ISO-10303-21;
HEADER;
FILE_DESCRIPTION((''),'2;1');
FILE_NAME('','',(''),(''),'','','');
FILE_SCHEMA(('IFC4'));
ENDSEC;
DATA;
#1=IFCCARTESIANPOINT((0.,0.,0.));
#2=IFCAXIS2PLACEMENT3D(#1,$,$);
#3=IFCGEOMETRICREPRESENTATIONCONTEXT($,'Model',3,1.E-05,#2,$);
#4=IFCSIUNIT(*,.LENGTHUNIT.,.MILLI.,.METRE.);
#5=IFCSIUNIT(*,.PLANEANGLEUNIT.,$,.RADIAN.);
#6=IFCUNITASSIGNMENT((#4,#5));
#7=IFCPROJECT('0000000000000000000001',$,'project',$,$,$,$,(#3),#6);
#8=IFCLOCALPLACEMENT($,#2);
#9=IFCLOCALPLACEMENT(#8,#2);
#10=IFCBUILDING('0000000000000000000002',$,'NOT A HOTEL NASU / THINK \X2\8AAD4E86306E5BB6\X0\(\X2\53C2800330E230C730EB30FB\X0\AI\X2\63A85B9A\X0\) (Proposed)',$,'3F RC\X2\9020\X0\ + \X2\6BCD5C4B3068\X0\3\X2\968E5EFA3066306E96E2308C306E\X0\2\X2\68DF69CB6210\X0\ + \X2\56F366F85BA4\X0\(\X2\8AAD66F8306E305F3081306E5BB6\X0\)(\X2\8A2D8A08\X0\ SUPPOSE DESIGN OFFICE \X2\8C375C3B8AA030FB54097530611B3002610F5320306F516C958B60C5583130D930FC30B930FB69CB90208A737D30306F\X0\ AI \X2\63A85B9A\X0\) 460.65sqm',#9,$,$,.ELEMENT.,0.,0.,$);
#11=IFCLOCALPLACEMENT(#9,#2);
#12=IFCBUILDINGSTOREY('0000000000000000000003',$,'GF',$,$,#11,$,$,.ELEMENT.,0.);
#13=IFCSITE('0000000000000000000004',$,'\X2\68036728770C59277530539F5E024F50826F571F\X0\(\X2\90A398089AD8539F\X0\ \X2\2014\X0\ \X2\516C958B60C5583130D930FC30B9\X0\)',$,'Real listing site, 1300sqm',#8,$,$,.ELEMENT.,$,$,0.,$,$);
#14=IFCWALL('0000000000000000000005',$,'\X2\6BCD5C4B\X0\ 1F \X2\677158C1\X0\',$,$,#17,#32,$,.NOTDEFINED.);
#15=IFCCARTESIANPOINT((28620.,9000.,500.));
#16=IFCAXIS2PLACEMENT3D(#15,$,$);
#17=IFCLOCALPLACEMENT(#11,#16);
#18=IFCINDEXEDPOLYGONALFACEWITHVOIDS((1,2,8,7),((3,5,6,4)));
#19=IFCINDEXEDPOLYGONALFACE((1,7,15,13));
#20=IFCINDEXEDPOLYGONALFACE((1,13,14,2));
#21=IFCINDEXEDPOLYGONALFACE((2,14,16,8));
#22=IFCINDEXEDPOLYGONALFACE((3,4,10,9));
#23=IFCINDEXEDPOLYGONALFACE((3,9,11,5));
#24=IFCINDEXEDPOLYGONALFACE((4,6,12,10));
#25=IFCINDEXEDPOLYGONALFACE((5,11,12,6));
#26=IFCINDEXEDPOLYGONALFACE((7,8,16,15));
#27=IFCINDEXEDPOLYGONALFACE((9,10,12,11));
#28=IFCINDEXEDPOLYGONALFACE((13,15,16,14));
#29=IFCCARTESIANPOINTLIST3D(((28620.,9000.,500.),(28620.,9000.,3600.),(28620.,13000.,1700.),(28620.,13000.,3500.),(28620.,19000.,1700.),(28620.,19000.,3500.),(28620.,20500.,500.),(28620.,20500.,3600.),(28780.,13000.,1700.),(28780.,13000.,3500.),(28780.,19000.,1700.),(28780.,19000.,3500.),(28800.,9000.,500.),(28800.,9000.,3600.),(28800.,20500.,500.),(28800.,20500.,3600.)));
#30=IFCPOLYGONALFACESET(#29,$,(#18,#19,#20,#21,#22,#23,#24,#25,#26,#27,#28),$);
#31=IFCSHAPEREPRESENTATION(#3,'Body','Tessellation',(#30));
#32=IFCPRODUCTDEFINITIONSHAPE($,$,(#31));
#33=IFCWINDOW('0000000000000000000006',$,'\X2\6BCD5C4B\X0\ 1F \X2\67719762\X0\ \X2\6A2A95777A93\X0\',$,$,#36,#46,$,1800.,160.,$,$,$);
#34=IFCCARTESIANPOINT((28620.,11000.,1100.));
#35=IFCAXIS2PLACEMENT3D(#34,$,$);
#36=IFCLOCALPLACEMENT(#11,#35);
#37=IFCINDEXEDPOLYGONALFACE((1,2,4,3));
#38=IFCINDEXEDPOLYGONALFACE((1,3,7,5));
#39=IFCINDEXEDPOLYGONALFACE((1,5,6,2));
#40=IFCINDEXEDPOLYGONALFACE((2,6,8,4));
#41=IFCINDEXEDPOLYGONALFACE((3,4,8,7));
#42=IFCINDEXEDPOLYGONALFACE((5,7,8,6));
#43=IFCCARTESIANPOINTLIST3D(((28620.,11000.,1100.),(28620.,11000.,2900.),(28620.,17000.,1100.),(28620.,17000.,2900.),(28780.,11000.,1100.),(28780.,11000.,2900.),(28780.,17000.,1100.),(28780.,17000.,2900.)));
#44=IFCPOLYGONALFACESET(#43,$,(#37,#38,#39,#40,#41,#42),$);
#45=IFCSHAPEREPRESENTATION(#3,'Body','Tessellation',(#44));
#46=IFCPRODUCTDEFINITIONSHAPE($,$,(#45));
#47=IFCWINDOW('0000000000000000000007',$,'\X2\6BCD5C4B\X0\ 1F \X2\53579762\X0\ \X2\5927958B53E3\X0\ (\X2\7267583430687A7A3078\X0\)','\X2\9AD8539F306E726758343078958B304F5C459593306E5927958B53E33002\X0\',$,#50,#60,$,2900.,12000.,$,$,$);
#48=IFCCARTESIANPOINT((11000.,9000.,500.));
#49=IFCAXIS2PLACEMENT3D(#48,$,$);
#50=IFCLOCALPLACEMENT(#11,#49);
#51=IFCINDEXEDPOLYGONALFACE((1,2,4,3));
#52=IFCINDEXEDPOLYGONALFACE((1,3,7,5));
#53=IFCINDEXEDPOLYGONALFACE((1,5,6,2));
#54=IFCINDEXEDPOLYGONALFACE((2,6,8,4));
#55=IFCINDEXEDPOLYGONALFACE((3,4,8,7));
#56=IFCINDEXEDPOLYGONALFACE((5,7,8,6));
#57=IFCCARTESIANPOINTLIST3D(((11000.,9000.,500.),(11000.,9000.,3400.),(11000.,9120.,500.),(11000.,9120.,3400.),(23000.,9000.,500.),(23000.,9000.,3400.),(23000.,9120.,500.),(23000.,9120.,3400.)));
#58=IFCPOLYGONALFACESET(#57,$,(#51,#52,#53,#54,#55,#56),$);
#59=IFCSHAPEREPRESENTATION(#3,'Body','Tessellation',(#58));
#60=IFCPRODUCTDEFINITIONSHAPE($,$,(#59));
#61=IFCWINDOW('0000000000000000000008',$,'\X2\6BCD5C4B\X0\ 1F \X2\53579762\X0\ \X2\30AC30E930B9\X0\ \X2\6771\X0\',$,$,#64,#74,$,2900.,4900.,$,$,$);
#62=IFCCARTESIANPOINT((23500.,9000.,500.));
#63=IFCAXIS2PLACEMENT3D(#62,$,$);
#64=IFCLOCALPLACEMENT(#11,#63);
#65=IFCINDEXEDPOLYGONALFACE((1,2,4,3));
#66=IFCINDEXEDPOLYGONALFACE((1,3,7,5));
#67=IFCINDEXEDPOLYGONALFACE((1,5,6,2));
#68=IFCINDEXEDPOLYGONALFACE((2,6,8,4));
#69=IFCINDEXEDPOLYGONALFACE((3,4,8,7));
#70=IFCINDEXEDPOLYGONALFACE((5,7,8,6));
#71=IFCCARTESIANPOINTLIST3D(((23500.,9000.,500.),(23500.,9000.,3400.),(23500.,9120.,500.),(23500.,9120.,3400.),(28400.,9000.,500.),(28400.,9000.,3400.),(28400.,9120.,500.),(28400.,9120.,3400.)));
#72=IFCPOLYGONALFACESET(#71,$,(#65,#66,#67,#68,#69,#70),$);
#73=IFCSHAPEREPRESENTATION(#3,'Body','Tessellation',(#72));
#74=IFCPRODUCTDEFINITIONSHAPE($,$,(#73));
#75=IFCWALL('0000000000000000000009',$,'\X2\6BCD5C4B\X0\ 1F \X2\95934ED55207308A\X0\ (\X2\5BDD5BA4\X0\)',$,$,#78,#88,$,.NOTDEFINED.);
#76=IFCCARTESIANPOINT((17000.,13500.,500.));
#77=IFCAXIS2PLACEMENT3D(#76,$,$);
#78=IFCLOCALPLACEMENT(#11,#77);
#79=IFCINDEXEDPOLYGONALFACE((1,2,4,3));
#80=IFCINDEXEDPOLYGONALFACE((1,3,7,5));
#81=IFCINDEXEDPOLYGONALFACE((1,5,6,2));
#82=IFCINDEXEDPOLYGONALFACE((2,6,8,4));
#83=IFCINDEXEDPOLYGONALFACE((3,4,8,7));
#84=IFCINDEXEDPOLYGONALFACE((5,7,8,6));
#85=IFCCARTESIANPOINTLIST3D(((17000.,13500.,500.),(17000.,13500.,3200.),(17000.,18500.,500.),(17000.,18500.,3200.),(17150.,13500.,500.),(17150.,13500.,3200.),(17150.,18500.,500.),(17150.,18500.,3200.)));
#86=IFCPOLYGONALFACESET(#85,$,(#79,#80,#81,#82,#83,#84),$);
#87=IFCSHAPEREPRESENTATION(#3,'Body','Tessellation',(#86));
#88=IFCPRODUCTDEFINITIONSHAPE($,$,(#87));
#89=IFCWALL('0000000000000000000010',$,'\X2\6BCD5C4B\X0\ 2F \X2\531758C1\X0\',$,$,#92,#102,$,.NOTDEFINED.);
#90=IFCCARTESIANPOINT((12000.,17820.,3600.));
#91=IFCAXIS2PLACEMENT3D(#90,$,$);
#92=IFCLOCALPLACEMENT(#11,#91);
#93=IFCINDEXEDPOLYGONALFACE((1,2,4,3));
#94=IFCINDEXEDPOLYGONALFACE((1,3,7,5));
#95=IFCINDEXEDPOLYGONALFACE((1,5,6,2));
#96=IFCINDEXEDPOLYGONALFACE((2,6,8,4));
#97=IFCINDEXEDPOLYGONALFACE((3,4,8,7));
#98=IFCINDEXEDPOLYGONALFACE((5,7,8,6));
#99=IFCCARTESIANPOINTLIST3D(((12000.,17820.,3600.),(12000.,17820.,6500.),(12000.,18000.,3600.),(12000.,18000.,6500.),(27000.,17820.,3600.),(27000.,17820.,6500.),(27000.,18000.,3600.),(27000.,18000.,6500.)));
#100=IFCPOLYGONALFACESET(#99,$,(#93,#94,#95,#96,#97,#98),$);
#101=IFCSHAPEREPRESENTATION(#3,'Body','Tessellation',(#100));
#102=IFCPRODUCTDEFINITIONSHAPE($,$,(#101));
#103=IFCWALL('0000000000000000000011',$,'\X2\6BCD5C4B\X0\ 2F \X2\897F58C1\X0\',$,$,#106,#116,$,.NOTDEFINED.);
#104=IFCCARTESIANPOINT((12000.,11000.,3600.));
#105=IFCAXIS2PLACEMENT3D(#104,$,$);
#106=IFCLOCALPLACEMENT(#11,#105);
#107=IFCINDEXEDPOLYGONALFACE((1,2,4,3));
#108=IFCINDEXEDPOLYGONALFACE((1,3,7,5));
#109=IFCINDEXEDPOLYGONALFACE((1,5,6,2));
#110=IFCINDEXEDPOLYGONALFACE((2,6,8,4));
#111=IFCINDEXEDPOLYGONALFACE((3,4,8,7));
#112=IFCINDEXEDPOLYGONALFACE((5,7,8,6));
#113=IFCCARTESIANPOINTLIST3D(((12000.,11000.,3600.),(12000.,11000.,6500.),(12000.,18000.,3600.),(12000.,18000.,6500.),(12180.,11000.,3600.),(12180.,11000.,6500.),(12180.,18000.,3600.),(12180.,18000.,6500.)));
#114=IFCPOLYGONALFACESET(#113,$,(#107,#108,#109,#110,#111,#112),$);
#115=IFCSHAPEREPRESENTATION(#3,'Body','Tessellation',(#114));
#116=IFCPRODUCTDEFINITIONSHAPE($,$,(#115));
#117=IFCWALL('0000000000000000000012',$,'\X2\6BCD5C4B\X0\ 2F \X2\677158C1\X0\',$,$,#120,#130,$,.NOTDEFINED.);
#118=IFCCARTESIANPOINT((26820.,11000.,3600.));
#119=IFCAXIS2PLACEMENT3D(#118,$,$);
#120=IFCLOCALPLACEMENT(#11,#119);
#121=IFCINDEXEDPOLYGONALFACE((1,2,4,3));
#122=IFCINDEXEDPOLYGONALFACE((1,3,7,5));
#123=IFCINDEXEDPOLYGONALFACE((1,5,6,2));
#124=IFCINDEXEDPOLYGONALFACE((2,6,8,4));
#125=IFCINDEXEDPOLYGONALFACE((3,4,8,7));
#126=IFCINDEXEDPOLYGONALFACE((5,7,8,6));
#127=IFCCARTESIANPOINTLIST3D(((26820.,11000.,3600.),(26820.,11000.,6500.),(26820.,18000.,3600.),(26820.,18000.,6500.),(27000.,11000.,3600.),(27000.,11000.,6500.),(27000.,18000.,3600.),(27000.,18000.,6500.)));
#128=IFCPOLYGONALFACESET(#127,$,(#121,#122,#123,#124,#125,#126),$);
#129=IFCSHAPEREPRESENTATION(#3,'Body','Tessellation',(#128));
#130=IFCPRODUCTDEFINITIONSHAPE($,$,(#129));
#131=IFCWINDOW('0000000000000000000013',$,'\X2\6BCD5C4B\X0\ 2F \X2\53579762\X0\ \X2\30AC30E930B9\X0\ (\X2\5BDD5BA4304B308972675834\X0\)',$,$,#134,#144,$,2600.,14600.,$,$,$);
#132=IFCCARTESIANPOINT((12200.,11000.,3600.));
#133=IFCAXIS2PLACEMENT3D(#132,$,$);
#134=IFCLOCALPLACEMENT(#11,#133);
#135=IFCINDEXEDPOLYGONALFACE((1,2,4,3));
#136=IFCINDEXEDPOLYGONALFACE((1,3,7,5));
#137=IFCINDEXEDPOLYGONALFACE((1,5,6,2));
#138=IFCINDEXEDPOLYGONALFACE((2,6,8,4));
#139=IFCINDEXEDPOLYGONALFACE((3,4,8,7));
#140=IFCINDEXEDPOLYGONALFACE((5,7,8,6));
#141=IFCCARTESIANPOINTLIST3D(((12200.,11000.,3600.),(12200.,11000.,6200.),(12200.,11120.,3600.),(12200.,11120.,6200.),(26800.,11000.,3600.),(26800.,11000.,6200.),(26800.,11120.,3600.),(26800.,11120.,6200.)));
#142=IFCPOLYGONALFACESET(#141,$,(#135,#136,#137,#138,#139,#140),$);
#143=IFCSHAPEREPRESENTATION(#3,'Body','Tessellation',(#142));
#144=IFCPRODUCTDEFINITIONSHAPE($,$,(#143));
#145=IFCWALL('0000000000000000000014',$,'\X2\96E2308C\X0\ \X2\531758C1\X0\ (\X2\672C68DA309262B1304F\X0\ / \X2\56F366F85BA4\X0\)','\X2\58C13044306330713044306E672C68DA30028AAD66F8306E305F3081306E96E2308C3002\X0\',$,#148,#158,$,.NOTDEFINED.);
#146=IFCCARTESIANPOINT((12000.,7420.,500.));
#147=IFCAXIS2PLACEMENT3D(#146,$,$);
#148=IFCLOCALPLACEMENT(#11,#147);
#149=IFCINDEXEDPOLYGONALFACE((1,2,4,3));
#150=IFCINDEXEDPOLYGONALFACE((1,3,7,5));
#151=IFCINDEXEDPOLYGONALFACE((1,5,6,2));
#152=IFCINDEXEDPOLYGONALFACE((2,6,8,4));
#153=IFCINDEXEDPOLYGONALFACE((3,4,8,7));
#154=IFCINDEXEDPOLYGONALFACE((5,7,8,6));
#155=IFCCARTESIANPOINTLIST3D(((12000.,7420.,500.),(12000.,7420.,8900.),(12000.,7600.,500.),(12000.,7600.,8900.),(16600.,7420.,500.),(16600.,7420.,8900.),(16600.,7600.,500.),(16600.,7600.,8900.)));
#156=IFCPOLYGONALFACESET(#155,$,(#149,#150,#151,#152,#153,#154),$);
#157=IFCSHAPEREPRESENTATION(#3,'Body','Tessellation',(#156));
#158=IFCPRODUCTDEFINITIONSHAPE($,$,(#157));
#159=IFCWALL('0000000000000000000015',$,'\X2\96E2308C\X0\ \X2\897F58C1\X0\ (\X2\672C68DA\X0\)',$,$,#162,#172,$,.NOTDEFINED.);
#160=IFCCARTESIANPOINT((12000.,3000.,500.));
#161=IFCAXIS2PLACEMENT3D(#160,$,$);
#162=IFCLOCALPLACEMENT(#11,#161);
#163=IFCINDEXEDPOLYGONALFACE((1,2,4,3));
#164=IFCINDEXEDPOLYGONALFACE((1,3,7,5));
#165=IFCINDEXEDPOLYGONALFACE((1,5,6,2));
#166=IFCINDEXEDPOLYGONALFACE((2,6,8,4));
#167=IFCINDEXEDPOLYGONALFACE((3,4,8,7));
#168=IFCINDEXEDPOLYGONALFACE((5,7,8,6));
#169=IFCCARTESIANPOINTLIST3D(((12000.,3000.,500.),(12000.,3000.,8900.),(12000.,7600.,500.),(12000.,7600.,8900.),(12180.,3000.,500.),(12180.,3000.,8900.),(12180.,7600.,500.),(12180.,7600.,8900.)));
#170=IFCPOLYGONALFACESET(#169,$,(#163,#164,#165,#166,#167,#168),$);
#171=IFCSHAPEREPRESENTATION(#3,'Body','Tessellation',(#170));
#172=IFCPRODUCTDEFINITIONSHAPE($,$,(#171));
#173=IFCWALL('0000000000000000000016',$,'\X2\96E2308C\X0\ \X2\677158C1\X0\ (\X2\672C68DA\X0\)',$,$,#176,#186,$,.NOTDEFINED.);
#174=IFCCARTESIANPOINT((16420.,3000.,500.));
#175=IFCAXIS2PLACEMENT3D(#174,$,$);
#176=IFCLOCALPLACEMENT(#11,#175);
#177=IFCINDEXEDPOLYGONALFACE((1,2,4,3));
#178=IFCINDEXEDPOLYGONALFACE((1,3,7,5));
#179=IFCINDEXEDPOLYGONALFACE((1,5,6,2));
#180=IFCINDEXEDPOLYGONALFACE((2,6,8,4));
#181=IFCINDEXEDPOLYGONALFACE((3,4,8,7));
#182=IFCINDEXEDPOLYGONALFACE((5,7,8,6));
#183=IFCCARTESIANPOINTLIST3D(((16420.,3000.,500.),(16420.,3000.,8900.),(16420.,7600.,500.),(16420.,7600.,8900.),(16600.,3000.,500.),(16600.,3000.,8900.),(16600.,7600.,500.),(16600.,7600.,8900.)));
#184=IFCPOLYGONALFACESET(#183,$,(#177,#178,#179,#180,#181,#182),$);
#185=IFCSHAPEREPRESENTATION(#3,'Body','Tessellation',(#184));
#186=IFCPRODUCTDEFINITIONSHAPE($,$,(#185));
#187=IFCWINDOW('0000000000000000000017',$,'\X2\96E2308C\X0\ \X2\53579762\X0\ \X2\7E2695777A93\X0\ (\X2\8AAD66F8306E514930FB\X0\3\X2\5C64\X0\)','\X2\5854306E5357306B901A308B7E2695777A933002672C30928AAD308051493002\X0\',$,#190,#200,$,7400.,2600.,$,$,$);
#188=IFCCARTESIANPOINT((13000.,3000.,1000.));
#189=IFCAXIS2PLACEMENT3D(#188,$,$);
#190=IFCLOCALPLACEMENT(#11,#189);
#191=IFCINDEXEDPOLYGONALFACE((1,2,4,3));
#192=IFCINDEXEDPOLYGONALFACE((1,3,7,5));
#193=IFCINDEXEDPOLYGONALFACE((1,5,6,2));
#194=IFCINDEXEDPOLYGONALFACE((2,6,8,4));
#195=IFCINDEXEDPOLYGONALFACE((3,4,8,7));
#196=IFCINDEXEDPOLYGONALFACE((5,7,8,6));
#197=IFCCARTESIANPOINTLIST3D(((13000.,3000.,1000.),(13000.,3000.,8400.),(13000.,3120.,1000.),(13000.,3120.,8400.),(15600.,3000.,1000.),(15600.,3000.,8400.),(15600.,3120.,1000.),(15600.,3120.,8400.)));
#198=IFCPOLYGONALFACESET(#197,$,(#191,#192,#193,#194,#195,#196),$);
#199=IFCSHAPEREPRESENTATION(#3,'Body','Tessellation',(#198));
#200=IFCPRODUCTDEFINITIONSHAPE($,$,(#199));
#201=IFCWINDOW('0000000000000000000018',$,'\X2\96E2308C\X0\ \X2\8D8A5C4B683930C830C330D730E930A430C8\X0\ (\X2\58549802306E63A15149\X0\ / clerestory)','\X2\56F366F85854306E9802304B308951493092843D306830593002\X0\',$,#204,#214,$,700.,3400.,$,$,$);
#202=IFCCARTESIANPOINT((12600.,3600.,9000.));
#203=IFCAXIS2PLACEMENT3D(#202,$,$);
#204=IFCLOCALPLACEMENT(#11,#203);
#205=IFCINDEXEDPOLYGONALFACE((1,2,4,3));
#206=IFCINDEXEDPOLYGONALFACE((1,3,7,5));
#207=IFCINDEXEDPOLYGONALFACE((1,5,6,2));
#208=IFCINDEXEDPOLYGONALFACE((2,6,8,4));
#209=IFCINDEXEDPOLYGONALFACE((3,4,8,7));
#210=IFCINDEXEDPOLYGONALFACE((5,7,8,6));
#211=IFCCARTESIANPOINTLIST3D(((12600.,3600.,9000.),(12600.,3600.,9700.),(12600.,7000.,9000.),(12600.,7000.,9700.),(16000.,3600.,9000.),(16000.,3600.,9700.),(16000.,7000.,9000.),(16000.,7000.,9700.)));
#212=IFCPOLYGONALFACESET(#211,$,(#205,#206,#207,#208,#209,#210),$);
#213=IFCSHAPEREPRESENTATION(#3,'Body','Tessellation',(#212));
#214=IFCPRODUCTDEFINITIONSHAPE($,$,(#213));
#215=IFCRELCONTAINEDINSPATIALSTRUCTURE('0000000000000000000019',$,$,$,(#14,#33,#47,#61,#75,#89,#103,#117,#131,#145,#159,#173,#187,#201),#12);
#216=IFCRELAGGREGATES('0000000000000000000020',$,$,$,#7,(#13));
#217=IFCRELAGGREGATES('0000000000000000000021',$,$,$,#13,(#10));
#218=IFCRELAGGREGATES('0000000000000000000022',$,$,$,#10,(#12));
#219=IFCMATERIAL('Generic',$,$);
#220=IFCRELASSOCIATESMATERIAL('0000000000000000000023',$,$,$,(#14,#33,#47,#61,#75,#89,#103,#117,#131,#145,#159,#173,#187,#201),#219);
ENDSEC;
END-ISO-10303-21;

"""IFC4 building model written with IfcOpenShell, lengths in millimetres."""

from ifc_helpers import new_model, si_unit, frame, frame_2d, origin, place, context, project, spatial, rectangle, extrude, material, element, fill, save


model = new_model("IFC4")

# Units and contexts
model_context = context("Model", 3, precision=1e-05, world=origin())
ifc_project = project(units=[si_unit("LENGTHUNIT", "METRE", prefix="MILLI"), si_unit("PLANEANGLEUNIT", "RADIAN")], contexts=[model_context])

# Site, building, storey
site_placement = place(None, origin())
site = spatial("IfcSite", under=ifc_project, at=site_placement, Name="栃木県大田原市佐良土(那須高原 — 公開情報ベース)", ObjectType="Real listing site, 1300sqm", CompositionType="ELEMENT", RefElevation=0.0)
building_placement = place(site_placement, origin())
building = spatial("IfcBuilding", under=site, at=building_placement, Name="NOT A HOTEL NASU / THINK 読了の家(参考モデル・AI推定) (Proposed)", ObjectType="3F RC造 + 母屋と3階建ての離れの2棟構成 + 図書室(読書のための家)(設計 SUPPOSE DESIGN OFFICE 谷尻誠・吉田愛。意匠は公開情報ベース・構造詳細は AI 推定) 460.65sqm", CompositionType="ELEMENT", ElevationOfRefHeight=0.0, ElevationOfTerrain=0.0)
storey_placement = place(building_placement, origin())
storey = spatial("IfcBuildingStorey", under=building, at=storey_placement, Name="GF", CompositionType="ELEMENT", Elevation=0.0)

# Shared definitions
ifc_material_1 = material(Name="Generic")

# Wall, opening, window
wall_1_placement = place(storey_placement, frame((28620.0, 9000.0, 500.0)))
wall_1 = element("IfcWall", 1, at=wall_1_placement, inside=storey, material=ifc_material_1, Name="母屋 1F 東壁", PredefinedType="NOTDEFINED", context=model_context, shape_type="SweptSolid", body=[
    extrude(rectangle(XDim=180.0, YDim=11500.0, at=frame_2d((90.0, 5750.0))), frame((28620.0, 9000.0, 500.0)), (0.0, 0.0, 1.0), 3100.0),
])
opening_placement = place(storey_placement, frame((28620.0, 11000.0, 1100.0)))
opening = element("IfcOpeningElement", 2, at=opening_placement, cuts=wall_1, PredefinedType="NOTDEFINED", context=model_context, shape_type="SweptSolid", body=[
    extrude(rectangle(XDim=160.0, YDim=6000.0, at=frame_2d((80.0, 3000.0))), frame((28620.0, 11000.0, 1100.0)), (0.0, 0.0, 1.0), 1800.0),
])
window_1_placement = place(storey_placement, frame((28620.0, 11000.0, 1100.0)))
window_1 = element("IfcWindow", 3, at=window_1_placement, inside=storey, material=ifc_material_1, Name="母屋 1F 東面 横長窓", OverallHeight=1800.0, OverallWidth=160.0, context=model_context, shape_type="SweptSolid", body=[
    extrude(rectangle(XDim=160.0, YDim=6000.0, at=frame_2d((80.0, 3000.0))), frame((28620.0, 11000.0, 1100.0)), (0.0, 0.0, 1.0), 1800.0),
])
fill(opening, window_1)

# Windows
window_2_placement = place(storey_placement, frame((11000.0, 9000.0, 500.0)))
element("IfcWindow", 4, at=window_2_placement, inside=storey, material=ifc_material_1, Name="母屋 1F 南面 大開口 (牧場と空へ)", Description="高原の牧場へ開く居間の大開口。", OverallHeight=2900.0, OverallWidth=12000.0, context=model_context, shape_type="SweptSolid", body=[
    extrude(rectangle(XDim=12000.0, YDim=120.0, at=frame_2d((6000.0, 60.0))), frame((11000.0, 9000.0, 500.0)), (0.0, 0.0, 1.0), 2900.0),
])
window_3_placement = place(storey_placement, frame((23500.0, 9000.0, 500.0)))
element("IfcWindow", 5, at=window_3_placement, inside=storey, material=ifc_material_1, Name="母屋 1F 南面 ガラス 東", OverallHeight=2900.0, OverallWidth=4900.0, context=model_context, shape_type="SweptSolid", body=[
    extrude(rectangle(XDim=4900.0, YDim=120.0, at=frame_2d((2450.0, 60.0))), frame((23500.0, 9000.0, 500.0)), (0.0, 0.0, 1.0), 2900.0),
])

# Walls
wall_2_placement = place(storey_placement, frame((17000.0, 13500.0, 500.0)))
element("IfcWall", 6, at=wall_2_placement, inside=storey, material=ifc_material_1, Name="母屋 1F 間仕切り (寝室)", PredefinedType="NOTDEFINED", context=model_context, shape_type="SweptSolid", body=[
    extrude(rectangle(XDim=150.0, YDim=5000.0, at=frame_2d((75.0, 2500.0))), frame((17000.0, 13500.0, 500.0)), (0.0, 0.0, 1.0), 2700.0),
])
wall_3_placement = place(storey_placement, frame((12000.0, 17820.0, 3600.0)))
element("IfcWall", 7, at=wall_3_placement, inside=storey, material=ifc_material_1, Name="母屋 2F 北壁", PredefinedType="NOTDEFINED", context=model_context, shape_type="SweptSolid", body=[
    extrude(rectangle(XDim=15000.0, YDim=180.0, at=frame_2d((7500.0, 90.0))), frame((12000.0, 17820.0, 3600.0)), (0.0, 0.0, 1.0), 2900.0),
])
wall_4_placement = place(storey_placement, frame((12000.0, 11000.0, 3600.0)))
element("IfcWall", 8, at=wall_4_placement, inside=storey, material=ifc_material_1, Name="母屋 2F 西壁", PredefinedType="NOTDEFINED", context=model_context, shape_type="SweptSolid", body=[
    extrude(rectangle(XDim=180.0, YDim=7000.0, at=frame_2d((90.0, 3500.0))), frame((12000.0, 11000.0, 3600.0)), (0.0, 0.0, 1.0), 2900.0),
])
wall_5_placement = place(storey_placement, frame((26820.0, 11000.0, 3600.0)))
element("IfcWall", 9, at=wall_5_placement, inside=storey, material=ifc_material_1, Name="母屋 2F 東壁", PredefinedType="NOTDEFINED", context=model_context, shape_type="SweptSolid", body=[
    extrude(rectangle(XDim=180.0, YDim=7000.0, at=frame_2d((90.0, 3500.0))), frame((26820.0, 11000.0, 3600.0)), (0.0, 0.0, 1.0), 2900.0),
])

# Window
window_4_placement = place(storey_placement, frame((12200.0, 11000.0, 3600.0)))
element("IfcWindow", 10, at=window_4_placement, inside=storey, material=ifc_material_1, Name="母屋 2F 南面 ガラス (寝室から牧場)", OverallHeight=2600.0, OverallWidth=14600.0, context=model_context, shape_type="SweptSolid", body=[
    extrude(rectangle(XDim=14600.0, YDim=120.0, at=frame_2d((7300.0, 60.0))), frame((12200.0, 11000.0, 3600.0)), (0.0, 0.0, 1.0), 2600.0),
])

# Walls
wall_6_placement = place(storey_placement, frame((12000.0, 7420.0, 500.0)))
element("IfcWall", 11, at=wall_6_placement, inside=storey, material=ifc_material_1, Name="離れ 北壁 (本棚を抱く / 図書室)", Description="壁いっぱいの本棚。読書のための離れ。", PredefinedType="NOTDEFINED", context=model_context, shape_type="SweptSolid", body=[
    extrude(rectangle(XDim=4600.0, YDim=180.0, at=frame_2d((2300.0, 90.0))), frame((12000.0, 7420.0, 500.0)), (0.0, 0.0, 1.0), 8400.0),
])
wall_7_placement = place(storey_placement, frame((12000.0, 3000.0, 500.0)))
element("IfcWall", 12, at=wall_7_placement, inside=storey, material=ifc_material_1, Name="離れ 西壁 (本棚)", PredefinedType="NOTDEFINED", context=model_context, shape_type="SweptSolid", body=[
    extrude(rectangle(XDim=180.0, YDim=4600.0, at=frame_2d((90.0, 2300.0))), frame((12000.0, 3000.0, 500.0)), (0.0, 0.0, 1.0), 8400.0),
])
wall_8_placement = place(storey_placement, frame((16420.0, 3000.0, 500.0)))
element("IfcWall", 13, at=wall_8_placement, inside=storey, material=ifc_material_1, Name="離れ 東壁 (本棚)", PredefinedType="NOTDEFINED", context=model_context, shape_type="SweptSolid", body=[
    extrude(rectangle(XDim=180.0, YDim=4600.0, at=frame_2d((90.0, 2300.0))), frame((16420.0, 3000.0, 500.0)), (0.0, 0.0, 1.0), 8400.0),
])

# Windows
window_5_placement = place(storey_placement, frame((13000.0, 3000.0, 1000.0)))
element("IfcWindow", 14, at=window_5_placement, inside=storey, material=ifc_material_1, Name="離れ 南面 縦長窓 (読書の光・3層)", Description="塔の南に通る縦長窓。本を読む光。", OverallHeight=7400.0, OverallWidth=2600.0, context=model_context, shape_type="SweptSolid", body=[
    extrude(rectangle(XDim=2600.0, YDim=120.0, at=frame_2d((1300.0, 60.0))), frame((13000.0, 3000.0, 1000.0)), (0.0, 0.0, 1.0), 7400.0),
])
window_6_placement = place(storey_placement, frame((12600.0, 3600.0, 9000.0)))
element("IfcWindow", 15, at=window_6_placement, inside=storey, material=ifc_material_1, Name="離れ 越屋根トップライト (塔頂の採光 / clerestory)", Description="図書塔の頂から光を落とす。", OverallHeight=700.0, OverallWidth=3400.0, context=model_context, shape_type="SweptSolid", body=[
    extrude(rectangle(XDim=3400.0, YDim=3400.0, at=frame_2d((1700.0, 1700.0))), frame((12600.0, 3600.0, 9000.0)), (0.0, 0.0, 1.0), 700.0),
])

save(model, "model.ifc")
